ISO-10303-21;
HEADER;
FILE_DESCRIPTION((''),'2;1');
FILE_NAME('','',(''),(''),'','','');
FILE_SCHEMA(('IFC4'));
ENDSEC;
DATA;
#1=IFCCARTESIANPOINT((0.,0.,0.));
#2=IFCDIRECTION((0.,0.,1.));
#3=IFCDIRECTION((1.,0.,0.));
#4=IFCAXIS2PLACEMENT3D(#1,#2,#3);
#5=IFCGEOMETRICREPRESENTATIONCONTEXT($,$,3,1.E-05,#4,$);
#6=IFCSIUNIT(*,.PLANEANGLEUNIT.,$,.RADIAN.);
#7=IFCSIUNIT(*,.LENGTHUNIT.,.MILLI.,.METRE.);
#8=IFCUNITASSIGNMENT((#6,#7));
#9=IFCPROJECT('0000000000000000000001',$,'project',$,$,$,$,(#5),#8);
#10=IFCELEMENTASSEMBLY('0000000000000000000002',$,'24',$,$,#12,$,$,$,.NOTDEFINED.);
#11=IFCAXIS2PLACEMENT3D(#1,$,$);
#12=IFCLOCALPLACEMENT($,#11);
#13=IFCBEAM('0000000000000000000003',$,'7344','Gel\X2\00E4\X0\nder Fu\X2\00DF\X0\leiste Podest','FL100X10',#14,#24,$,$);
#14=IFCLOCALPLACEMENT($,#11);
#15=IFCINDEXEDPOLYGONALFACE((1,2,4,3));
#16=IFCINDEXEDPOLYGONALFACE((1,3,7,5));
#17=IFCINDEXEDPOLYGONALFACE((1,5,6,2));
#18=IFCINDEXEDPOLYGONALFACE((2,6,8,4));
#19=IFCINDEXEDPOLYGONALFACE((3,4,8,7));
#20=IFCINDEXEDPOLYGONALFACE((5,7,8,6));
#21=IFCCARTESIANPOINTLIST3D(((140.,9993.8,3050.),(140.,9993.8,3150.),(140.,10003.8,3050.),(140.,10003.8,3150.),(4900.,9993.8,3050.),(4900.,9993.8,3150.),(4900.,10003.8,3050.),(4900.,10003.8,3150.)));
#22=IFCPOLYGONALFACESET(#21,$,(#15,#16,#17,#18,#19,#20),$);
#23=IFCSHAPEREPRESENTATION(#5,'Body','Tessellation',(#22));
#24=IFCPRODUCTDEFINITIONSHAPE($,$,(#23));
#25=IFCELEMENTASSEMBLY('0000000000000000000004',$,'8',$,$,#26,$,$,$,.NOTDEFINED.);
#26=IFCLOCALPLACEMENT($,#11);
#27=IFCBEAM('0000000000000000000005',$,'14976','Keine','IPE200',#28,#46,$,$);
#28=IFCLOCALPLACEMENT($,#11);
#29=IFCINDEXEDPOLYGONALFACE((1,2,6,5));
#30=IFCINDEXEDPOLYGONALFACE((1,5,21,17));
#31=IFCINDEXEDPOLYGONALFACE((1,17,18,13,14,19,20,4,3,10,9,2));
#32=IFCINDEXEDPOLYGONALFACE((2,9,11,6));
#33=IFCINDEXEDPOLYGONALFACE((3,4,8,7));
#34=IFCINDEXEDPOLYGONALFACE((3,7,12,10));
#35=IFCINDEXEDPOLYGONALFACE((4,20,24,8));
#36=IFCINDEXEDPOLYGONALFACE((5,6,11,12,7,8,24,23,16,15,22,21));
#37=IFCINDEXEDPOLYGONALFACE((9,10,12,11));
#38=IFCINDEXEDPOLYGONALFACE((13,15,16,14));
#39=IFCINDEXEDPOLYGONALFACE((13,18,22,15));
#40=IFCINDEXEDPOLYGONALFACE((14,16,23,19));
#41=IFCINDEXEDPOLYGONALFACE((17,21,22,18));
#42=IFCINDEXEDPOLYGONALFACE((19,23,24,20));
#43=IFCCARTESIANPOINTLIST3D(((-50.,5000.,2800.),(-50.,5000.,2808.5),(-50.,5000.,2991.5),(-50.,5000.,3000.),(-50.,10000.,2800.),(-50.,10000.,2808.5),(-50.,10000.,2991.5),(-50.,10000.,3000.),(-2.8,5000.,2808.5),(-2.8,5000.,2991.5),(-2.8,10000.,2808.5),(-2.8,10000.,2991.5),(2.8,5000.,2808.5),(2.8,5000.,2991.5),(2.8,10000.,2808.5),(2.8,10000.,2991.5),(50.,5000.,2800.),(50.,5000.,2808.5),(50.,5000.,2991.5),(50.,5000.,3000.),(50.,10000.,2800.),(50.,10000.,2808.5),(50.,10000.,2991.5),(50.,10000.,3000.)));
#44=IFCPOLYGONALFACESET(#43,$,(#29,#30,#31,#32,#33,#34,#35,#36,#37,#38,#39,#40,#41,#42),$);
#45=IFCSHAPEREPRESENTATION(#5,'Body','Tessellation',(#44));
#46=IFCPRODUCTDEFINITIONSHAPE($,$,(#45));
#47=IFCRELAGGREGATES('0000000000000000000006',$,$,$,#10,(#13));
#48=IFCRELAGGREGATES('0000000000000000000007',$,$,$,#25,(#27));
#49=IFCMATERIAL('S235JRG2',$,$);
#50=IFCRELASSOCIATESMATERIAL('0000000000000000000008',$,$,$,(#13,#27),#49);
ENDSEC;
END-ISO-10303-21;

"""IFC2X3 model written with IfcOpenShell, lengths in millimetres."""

from ifc_helpers import new_model, si_unit, frame, origin_with_axes, place, context, project, polyline, outline, extrude, material, element, aggregate, save


model = new_model("IFC2X3")

# Units and contexts
context_of_model = context(None, 3, precision=1e-05, world=origin_with_axes())
ifc_project = project(units=[si_unit("PLANEANGLEUNIT", "RADIAN"), si_unit("LENGTHUNIT", "METRE", prefix="MILLI")], contexts=[context_of_model])

# Element assembly, beam
assembly_1_placement = place(None, frame((140.0, 9998.8, 6100.0), z_axis=(0.0, 0.0, 1.0), x_axis=(1.0, 0.0, 0.0)))
assembly_1 = element("IfcElementAssembly", 1, at=assembly_1_placement, Name="24", PredefinedType="NOTDEFINED")
ifc_material = material(Name="S235JRG2")
placement_1 = place(None, frame((140.0, 9998.8, 3100.0), z_axis=(0.0, 0.0, 1.0), x_axis=(1.0, 0.0, 0.0)))
beam_1_placement = place(placement_1, origin_with_axes())
beam_1 = element("IfcBeam", 2, at=beam_1_placement, material=ifc_material, Name="7344", Description="Geländer Fußleiste Podest", ObjectType="FL100X10", context=context_of_model, shape_type="SweptSolid", body=[
    extrude(outline(polyline([(5.0, -50.0), (5.0, 50.0), (-5.0, 50.0), (-5.0, -50.0), (5.0, -50.0), (5.0, -50.0)])), frame((0.0, 0.0, 0.0), z_axis=(1.0, 0.0, 0.0), x_axis=(0.0, 1.0, 0.0)), (0.0, 0.0, 1.0), 4760.0),
])
aggregate(assembly_1, [beam_1])

# Element assembly, beam
assembly_2_placement = place(None, frame((0.0, 10000.0, 6000.0), z_axis=(0.0, 0.0, 1.0), x_axis=(0.0, -1.0, 0.0)))
assembly_2 = element("IfcElementAssembly", 3, at=assembly_2_placement, Name="8", PredefinedType="NOTDEFINED")
placement_2 = place(None, frame((0.0, 10000.0, 2900.0), z_axis=(0.0, 0.0, 1.0), x_axis=(0.0, -1.0, 0.0)))
beam_2_placement = place(placement_2, origin_with_axes())
beam_2 = element("IfcBeam", 4, at=beam_2_placement, material=ifc_material, Name="14976", Description="Keine", ObjectType="IPE200", context=context_of_model, shape_type="SweptSolid", body=[
    extrude(outline(polyline([(50.0, -100.0), (50.0, -91.5), (2.8, -91.5), (2.8, 91.5), (50.0, 91.5), (50.0, 100.0), (-50.0, 100.0), (-50.0, 91.5), (-2.8, 91.5), (-2.8, -91.5), (-50.0, -91.5), (-50.0, -100.0), (50.0, -100.0), (50.0, -100.0)])), frame((0.0, 0.0, 0.0), z_axis=(1.0, 0.0, 0.0), x_axis=(0.0, 1.0, 0.0)), (0.0, 0.0, 1.0), 5000.0),
])
aggregate(assembly_2, [beam_2])

save(model, "model.ifc")
